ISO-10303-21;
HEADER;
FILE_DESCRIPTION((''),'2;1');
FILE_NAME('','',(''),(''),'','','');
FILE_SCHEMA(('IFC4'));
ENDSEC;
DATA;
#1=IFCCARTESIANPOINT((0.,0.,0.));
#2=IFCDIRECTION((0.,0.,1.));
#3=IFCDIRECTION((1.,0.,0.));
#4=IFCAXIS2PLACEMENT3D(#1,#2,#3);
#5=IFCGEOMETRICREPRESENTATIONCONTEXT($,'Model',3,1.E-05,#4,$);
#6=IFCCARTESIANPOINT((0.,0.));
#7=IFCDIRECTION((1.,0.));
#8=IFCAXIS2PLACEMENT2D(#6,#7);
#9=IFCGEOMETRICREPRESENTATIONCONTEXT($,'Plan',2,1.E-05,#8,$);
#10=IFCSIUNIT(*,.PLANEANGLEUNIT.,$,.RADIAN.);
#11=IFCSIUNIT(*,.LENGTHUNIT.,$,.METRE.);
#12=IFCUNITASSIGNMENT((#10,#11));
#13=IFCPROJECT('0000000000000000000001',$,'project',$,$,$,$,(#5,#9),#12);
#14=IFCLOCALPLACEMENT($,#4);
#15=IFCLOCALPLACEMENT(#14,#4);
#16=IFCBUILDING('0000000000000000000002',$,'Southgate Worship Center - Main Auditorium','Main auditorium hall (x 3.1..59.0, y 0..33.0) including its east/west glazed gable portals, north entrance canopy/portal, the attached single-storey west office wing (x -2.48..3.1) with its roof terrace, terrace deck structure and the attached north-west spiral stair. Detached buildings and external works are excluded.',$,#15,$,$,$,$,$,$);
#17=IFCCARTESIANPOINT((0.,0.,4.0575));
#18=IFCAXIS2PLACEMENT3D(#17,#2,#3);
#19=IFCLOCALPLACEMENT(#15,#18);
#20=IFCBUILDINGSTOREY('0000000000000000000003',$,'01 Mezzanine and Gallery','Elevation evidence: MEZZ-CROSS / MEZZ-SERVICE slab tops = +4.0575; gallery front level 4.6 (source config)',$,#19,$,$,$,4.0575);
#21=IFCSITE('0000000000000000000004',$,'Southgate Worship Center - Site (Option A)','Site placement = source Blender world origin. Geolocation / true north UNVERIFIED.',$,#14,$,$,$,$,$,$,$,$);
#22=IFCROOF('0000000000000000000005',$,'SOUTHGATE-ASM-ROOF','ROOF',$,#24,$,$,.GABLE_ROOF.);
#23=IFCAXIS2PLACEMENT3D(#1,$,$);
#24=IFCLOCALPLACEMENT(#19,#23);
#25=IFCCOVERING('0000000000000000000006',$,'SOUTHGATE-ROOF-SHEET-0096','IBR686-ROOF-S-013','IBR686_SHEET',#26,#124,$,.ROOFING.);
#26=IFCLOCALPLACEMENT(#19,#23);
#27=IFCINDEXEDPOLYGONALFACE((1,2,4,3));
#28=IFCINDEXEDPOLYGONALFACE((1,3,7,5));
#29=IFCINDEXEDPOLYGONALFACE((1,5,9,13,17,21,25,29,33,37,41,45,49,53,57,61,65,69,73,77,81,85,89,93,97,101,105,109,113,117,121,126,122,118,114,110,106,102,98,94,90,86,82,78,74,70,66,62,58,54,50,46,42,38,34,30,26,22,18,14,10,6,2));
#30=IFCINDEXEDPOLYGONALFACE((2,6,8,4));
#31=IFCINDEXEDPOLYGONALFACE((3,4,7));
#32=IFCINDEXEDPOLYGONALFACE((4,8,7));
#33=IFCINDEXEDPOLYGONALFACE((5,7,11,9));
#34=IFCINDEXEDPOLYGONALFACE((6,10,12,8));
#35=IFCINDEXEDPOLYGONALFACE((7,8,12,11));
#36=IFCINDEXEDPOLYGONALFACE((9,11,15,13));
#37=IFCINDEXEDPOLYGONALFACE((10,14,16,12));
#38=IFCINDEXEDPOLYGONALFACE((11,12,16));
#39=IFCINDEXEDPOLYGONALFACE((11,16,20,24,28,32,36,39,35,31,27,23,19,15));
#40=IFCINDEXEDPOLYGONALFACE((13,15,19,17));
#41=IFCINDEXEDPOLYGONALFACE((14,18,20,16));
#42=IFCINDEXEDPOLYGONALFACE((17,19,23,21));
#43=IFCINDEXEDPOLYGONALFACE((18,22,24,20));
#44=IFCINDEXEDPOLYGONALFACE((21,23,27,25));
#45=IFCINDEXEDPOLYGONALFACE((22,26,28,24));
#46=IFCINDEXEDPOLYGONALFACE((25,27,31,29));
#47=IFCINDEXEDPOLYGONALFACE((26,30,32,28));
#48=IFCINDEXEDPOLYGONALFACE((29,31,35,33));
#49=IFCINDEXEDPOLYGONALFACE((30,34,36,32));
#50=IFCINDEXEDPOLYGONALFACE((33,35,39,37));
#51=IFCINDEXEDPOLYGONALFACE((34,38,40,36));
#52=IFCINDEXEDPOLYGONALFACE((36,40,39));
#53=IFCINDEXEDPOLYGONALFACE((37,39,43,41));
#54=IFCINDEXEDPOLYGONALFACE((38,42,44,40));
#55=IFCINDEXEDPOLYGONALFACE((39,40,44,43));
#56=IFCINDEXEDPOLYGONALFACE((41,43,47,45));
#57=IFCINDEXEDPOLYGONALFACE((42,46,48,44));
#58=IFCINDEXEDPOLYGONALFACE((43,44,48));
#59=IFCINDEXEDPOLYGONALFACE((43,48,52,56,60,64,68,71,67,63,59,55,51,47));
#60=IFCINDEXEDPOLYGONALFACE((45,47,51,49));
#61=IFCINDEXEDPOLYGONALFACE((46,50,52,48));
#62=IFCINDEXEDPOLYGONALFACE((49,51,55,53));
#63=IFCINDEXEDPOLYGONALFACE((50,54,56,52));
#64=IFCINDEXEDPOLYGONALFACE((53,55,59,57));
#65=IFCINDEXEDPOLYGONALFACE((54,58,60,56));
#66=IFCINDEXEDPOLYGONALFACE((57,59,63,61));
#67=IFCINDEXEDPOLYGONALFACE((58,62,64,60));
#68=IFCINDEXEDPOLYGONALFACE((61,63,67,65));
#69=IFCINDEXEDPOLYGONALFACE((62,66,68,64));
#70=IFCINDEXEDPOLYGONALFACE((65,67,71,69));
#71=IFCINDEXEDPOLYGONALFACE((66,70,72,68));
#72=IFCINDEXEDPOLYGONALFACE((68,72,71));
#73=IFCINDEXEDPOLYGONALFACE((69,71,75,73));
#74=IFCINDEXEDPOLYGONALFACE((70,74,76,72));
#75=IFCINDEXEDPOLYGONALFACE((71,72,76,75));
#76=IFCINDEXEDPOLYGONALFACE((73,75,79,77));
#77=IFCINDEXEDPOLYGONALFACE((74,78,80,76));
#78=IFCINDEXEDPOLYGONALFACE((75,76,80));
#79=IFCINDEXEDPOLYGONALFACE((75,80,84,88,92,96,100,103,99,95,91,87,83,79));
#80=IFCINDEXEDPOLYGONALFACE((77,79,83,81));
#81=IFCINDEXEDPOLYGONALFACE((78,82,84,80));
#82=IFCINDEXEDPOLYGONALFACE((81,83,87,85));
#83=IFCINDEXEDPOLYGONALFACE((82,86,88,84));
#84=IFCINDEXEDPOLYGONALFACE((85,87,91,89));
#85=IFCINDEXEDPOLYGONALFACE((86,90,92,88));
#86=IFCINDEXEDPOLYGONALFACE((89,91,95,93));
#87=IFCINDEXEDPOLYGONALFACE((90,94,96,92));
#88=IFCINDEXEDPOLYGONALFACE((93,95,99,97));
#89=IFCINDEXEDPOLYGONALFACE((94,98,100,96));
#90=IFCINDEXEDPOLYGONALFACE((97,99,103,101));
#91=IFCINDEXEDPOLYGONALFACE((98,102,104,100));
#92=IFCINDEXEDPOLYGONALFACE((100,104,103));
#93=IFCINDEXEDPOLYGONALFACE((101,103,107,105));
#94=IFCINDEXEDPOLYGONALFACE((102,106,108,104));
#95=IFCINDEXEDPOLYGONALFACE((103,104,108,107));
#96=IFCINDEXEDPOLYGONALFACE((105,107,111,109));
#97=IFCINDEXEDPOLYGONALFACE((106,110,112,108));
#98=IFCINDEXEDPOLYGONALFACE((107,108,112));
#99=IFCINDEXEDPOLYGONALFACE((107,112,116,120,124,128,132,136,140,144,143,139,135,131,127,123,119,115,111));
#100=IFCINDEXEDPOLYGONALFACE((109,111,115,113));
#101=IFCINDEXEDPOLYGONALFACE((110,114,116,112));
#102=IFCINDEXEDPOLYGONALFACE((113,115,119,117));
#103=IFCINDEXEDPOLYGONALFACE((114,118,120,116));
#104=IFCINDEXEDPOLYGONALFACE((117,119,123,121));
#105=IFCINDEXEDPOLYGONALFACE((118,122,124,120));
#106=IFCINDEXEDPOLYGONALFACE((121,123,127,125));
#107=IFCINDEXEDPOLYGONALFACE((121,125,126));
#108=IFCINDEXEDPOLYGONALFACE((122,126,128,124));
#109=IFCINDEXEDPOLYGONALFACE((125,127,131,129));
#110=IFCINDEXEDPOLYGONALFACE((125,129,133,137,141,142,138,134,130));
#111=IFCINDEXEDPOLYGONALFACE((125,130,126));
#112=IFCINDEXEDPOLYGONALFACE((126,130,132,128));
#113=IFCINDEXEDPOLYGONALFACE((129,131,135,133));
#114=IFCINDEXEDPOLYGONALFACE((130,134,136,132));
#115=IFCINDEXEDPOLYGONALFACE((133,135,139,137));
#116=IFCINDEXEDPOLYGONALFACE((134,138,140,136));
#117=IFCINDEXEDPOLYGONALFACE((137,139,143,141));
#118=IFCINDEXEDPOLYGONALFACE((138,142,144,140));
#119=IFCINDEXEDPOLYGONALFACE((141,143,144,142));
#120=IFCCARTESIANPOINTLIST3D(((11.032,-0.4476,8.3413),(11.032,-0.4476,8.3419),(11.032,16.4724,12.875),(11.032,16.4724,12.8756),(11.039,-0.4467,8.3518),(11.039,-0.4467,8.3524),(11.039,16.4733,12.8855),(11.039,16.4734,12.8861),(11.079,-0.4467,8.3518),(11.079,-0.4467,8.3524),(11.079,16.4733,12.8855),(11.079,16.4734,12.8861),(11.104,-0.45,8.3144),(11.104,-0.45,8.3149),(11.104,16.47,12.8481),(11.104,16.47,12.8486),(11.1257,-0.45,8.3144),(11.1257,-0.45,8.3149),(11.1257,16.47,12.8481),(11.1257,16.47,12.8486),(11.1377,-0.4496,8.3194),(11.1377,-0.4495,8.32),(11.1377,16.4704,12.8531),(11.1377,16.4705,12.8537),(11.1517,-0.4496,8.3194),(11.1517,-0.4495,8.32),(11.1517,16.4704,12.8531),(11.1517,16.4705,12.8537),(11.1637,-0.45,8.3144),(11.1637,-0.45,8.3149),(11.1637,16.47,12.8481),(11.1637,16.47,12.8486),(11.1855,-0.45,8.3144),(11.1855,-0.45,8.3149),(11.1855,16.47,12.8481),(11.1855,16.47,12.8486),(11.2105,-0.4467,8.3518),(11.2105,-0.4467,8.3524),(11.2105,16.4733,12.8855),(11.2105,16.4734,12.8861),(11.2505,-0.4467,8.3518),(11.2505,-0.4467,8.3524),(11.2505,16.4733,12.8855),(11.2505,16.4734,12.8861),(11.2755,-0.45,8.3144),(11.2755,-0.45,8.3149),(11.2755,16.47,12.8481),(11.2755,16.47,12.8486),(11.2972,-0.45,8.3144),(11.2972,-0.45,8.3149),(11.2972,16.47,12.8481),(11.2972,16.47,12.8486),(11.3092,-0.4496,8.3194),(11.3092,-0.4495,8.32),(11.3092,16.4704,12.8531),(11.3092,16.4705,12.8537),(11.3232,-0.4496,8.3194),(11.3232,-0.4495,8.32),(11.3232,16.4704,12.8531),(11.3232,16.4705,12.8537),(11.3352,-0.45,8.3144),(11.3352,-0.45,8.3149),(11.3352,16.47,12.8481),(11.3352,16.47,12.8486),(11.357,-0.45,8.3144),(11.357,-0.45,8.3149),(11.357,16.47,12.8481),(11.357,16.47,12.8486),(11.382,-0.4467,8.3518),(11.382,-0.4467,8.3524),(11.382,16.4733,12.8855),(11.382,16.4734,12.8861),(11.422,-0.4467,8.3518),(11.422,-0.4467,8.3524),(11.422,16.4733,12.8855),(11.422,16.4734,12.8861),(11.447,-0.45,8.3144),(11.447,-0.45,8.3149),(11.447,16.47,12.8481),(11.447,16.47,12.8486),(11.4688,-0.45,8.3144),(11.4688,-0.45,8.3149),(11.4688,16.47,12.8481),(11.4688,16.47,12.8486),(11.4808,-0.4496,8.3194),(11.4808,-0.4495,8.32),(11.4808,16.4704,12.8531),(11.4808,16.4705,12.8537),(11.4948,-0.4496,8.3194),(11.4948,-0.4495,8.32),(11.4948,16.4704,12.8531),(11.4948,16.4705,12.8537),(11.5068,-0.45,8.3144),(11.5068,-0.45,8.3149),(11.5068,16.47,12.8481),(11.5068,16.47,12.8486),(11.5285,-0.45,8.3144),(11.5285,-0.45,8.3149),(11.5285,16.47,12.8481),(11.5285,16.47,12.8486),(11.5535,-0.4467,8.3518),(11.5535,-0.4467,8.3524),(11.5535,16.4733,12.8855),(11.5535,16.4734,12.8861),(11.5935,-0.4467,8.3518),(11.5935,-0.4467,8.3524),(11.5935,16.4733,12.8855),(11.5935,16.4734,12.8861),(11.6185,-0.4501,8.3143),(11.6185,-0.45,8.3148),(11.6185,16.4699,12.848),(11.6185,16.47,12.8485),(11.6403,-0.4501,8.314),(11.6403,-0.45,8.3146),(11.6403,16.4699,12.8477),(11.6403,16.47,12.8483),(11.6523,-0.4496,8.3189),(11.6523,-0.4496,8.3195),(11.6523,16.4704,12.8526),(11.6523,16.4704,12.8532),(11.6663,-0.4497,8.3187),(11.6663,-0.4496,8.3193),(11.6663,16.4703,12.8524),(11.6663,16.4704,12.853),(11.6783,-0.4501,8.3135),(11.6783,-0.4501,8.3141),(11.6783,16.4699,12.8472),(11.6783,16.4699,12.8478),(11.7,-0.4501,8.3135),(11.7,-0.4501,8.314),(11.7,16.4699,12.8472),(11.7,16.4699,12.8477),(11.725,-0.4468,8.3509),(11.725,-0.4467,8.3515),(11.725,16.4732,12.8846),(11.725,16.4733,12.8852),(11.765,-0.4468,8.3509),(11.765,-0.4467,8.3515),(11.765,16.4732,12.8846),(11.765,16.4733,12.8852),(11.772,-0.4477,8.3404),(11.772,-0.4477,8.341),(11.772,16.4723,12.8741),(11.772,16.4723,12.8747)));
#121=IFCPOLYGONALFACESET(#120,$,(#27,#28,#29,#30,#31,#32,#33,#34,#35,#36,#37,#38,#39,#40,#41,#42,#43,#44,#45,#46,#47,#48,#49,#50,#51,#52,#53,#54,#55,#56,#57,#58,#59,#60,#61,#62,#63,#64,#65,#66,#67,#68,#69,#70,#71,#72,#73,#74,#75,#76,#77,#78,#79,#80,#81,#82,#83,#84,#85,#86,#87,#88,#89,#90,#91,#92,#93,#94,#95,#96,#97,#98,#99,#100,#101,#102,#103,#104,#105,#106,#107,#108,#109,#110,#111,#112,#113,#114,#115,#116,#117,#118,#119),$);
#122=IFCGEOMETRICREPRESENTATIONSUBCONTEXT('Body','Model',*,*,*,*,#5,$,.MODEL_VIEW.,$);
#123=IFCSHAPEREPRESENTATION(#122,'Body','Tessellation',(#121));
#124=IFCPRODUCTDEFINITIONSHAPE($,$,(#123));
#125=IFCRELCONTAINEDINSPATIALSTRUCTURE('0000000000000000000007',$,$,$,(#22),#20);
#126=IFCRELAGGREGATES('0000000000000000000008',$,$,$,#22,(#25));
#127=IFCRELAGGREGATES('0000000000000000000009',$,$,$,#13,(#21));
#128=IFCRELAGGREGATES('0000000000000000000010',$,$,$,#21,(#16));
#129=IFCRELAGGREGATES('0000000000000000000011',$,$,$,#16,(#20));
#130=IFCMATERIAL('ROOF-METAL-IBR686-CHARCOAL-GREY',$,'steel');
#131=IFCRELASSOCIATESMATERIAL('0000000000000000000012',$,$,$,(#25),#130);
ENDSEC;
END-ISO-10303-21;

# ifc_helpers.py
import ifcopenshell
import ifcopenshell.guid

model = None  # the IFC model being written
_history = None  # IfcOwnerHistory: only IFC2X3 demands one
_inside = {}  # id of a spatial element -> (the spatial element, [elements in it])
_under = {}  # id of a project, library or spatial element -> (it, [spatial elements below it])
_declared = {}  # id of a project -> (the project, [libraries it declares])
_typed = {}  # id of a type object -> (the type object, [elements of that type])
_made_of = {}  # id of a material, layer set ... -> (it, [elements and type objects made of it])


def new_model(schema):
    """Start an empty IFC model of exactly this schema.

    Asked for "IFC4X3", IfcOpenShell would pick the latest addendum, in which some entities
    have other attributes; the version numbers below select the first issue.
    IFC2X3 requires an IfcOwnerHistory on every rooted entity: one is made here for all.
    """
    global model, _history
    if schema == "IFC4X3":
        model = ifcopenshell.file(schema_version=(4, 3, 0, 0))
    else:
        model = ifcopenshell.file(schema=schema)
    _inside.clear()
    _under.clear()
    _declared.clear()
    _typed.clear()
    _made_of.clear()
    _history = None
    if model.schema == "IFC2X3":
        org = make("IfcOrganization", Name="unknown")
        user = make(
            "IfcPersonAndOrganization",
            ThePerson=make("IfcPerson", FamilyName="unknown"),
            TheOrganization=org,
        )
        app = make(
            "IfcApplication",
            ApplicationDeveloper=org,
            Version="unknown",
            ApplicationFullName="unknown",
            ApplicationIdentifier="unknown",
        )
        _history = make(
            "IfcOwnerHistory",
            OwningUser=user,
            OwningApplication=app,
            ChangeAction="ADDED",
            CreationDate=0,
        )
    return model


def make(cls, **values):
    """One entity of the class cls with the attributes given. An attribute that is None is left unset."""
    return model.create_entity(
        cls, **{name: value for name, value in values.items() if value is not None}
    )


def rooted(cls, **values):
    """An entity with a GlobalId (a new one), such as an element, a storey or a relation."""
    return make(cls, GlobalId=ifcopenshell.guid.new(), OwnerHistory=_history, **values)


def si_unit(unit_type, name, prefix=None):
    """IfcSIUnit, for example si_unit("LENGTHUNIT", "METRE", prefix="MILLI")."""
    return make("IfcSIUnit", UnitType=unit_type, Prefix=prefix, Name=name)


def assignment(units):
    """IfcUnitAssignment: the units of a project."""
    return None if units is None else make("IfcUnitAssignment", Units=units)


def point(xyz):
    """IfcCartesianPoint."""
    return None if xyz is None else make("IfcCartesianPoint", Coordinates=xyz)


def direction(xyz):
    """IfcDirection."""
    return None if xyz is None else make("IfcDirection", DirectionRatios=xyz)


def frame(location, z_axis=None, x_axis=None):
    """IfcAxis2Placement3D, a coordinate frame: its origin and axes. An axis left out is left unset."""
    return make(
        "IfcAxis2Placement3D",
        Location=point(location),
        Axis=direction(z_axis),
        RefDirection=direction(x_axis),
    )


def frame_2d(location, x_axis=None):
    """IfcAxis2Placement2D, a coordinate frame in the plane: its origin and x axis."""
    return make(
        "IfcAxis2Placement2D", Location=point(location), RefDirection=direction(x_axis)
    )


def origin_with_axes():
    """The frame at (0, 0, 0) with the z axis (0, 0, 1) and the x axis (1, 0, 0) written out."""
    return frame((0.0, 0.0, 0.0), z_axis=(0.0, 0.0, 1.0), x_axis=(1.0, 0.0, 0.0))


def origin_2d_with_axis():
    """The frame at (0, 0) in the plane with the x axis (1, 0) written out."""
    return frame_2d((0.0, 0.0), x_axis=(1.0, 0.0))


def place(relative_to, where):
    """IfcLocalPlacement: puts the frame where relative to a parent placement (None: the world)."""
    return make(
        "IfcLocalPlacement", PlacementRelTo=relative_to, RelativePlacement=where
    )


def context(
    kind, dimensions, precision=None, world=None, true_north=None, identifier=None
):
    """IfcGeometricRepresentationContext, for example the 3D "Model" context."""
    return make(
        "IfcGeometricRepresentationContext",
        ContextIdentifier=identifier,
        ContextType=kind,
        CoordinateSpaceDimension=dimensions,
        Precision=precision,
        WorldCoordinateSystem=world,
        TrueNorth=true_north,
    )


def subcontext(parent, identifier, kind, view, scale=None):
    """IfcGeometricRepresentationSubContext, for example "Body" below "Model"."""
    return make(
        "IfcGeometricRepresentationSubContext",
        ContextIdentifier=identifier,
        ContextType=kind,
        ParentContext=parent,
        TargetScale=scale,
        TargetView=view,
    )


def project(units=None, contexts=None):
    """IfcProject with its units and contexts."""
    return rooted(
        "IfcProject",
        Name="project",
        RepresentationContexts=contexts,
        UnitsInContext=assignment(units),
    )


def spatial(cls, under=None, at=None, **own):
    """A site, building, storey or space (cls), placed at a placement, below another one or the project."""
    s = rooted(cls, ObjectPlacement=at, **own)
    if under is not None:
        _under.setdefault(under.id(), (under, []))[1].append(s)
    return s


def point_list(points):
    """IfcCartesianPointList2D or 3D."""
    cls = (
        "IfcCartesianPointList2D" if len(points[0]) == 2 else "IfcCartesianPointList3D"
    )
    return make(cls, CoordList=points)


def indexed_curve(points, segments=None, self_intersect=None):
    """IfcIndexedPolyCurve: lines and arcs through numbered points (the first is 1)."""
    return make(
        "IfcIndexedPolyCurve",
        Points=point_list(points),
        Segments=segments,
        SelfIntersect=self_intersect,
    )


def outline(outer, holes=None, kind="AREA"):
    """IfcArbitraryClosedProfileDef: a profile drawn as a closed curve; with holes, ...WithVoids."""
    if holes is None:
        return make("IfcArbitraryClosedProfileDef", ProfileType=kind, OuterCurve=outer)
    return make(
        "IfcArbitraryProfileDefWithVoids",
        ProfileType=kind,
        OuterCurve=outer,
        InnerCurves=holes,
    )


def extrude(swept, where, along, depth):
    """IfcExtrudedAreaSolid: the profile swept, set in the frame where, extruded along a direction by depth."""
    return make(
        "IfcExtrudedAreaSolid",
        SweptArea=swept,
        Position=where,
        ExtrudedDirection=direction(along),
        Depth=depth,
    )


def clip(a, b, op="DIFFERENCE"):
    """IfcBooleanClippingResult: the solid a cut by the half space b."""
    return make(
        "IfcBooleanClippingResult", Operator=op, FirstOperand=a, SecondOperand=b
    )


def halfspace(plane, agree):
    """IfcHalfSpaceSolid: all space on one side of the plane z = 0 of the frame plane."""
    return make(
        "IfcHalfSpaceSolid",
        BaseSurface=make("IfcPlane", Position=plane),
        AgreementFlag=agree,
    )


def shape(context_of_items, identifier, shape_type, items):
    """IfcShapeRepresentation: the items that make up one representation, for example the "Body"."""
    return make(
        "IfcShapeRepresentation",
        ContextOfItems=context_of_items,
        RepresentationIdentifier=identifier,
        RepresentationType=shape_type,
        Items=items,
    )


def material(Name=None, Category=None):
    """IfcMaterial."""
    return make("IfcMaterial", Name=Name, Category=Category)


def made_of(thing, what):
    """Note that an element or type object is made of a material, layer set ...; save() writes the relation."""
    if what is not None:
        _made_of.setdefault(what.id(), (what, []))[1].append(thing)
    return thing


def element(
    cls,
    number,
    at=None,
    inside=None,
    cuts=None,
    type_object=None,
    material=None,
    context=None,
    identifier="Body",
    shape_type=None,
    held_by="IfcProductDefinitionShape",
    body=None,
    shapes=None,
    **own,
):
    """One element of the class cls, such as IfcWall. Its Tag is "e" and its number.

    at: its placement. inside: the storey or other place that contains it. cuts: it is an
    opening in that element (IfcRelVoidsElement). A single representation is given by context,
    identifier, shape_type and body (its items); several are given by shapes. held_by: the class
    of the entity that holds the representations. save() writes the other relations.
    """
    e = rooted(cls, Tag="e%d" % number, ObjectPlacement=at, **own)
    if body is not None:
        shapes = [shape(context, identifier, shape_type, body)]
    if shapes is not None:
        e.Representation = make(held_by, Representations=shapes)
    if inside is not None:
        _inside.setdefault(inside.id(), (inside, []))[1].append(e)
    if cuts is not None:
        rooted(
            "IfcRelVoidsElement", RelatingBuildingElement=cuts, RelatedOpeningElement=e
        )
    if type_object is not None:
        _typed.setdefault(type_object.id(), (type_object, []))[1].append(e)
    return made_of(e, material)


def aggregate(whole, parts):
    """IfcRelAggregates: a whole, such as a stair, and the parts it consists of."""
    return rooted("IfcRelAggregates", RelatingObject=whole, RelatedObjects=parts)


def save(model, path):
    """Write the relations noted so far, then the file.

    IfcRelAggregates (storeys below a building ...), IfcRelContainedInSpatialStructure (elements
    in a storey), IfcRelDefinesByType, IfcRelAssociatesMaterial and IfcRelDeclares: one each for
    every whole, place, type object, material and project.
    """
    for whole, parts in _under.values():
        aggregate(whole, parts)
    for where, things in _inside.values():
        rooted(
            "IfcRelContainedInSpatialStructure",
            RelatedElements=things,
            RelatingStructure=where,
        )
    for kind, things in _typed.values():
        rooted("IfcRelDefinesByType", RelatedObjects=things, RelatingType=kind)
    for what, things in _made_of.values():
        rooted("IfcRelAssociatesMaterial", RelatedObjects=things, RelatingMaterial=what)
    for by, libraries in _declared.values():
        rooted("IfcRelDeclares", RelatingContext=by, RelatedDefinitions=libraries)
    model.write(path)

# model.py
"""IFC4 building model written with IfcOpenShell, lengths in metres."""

from ifc_helpers import new_model, si_unit, frame, origin_with_axes, origin_2d_with_axis, place, context, subcontext, project, spatial, indexed_curve, outline, extrude, clip, halfspace, material, element, aggregate, save


model = new_model("IFC4")

# Units and contexts
model_context = context("Model", 3, precision=1e-05, world=origin_with_axes())
plan_context = context("Plan", 2, precision=1e-05, world=origin_2d_with_axis())
body_context = subcontext(model_context, "Body", "Model", "MODEL_VIEW")
ifc_project = project(units=[si_unit("PLANEANGLEUNIT", "RADIAN"), si_unit("LENGTHUNIT", "METRE")], contexts=[model_context, plan_context])

# Site, building, storey
site_placement = place(None, origin_with_axes())
site = spatial("IfcSite", under=ifc_project, at=site_placement, Name="Southgate Worship Center - Site (Option A)", Description="Site placement = source Blender world origin. Geolocation / true north UNVERIFIED.")
building_placement = place(site_placement, origin_with_axes())
building = spatial("IfcBuilding", under=site, at=building_placement, Name="Southgate Worship Center - Main Auditorium", Description="Main auditorium hall (x 3.1..59.0, y 0..33.0) including its east/west glazed gable portals, north entrance canopy/portal, the attached single-storey west office wing (x -2.48..3.1) with its roof terrace, terrace deck structure and the attached north-west spiral stair. Detached buildings and external works are excluded.")
storey_placement = place(building_placement, frame((0.0, 0.0, 4.0575), z_axis=(0.0, 0.0, 1.0), x_axis=(1.0, 0.0, 0.0)))
storey = spatial("IfcBuildingStorey", under=building, at=storey_placement, Name="01 Mezzanine and Gallery", Description="Elevation evidence: MEZZ-CROSS / MEZZ-SERVICE slab tops = +4.0575; gallery front level 4.6 (source config)", Elevation=4.0575)

# Roof, covering
roof_placement = place(storey_placement, origin_with_axes())
roof = element("IfcRoof", 1, at=roof_placement, inside=storey, Name="SOUTHGATE-ASM-ROOF", Description="ROOF", PredefinedType="GABLE_ROOF")
ifc_material_1 = material(Name="ROOF-METAL-IBR686-CHARCOAL-GREY", Category="steel")
covering_1_placement = place(roof_placement, frame((11.032, -0.4501, 8.3135), z_axis=(0.0, 0.0, 1.0), x_axis=(1.0, 0.0, 0.0)))
covering_1 = element("IfcCovering", 2, at=covering_1_placement, material=ifc_material_1, Name="SOUTHGATE-ROOF-SHEET-0096", Description="IBR686-ROOF-S-013", ObjectType="IBR686_SHEET", PredefinedType="ROOFING", context=body_context, shape_type="Clipping", body=[
    clip(clip(extrude(outline(indexed_curve([(0.0, 0.0), (0.025, 0.0353), (0.065, 0.0353), (0.072, 0.0254), (0.072, 0.0259), (0.065, 0.0358), (0.025, 0.0358), (0.0, 0.0005), (-0.0217, 0.0005), (-0.0337, 0.0053), (-0.0477, 0.0053), (-0.0597, 0.0005), (-0.0815, 0.0005), (-0.1065, 0.0358), (-0.1465, 0.0358), (-0.1715, 0.0005), (-0.1932, 0.0005), (-0.2052, 0.0053), (-0.2192, 0.0053), (-0.2312, 0.0005), (-0.253, 0.0005), (-0.278, 0.0358), (-0.318, 0.0358), (-0.343, 0.0005), (-0.3647, 0.0005), (-0.3767, 0.0053), (-0.3907, 0.0053), (-0.4028, 0.0005), (-0.4245, 0.0005), (-0.4495, 0.0358), (-0.4895, 0.0358), (-0.5145, 0.0004), (-0.5363, 0.0002), (-0.5483, 0.0048), (-0.5623, 0.0046), (-0.5743, -0.0003), (-0.596, -0.0004), (-0.621, 0.0349), (-0.661, 0.0349), (-0.668, 0.0251), (-0.668, 0.0246), (-0.661, 0.0344), (-0.621, 0.0344), (-0.596, -0.0009), (-0.5743, -0.0008), (-0.5623, 0.0041), (-0.5483, 0.0043), (-0.5363, -0.0003), (-0.5145, -0.0001), (-0.4895, 0.0353), (-0.4495, 0.0353), (-0.4245, 0.0), (-0.4028, 0.0), (-0.3907, 0.0048), (-0.3767, 0.0048), (-0.3647, 0.0), (-0.343, 0.0), (-0.318, 0.0353), (-0.278, 0.0353), (-0.253, 0.0), (-0.2312, 0.0), (-0.2192, 0.0048), (-0.2052, 0.0048), (-0.1932, 0.0), (-0.1715, 0.0), (-0.1465, 0.0353), (-0.1065, 0.0353), (-0.0815, 0.0), (-0.0597, 0.0), (-0.0477, 0.0048), (-0.0337, 0.0048), (-0.0217, 0.0), (0.0, 0.0)], self_intersect=False)), frame((0.072, -0.0003, 0.0008), z_axis=(0.0, 0.965926, 0.258819), x_axis=(-1.0, 0.0, 0.0)), (0.0, 0.0, 1.0), 17.5303), halfspace(frame((0.37, 0.0012, 0.014), z_axis=(0.0, -0.996022, 0.089113), x_axis=(1.0, 0.0, 0.0)), False)), halfspace(frame((0.37, 16.9212, 4.5477), z_axis=(0.0, 0.996021, -0.089119), x_axis=(-1.0, 0.0, 0.0)), False)),
])
aggregate(roof, [covering_1])

save(model, "model.ifc")
